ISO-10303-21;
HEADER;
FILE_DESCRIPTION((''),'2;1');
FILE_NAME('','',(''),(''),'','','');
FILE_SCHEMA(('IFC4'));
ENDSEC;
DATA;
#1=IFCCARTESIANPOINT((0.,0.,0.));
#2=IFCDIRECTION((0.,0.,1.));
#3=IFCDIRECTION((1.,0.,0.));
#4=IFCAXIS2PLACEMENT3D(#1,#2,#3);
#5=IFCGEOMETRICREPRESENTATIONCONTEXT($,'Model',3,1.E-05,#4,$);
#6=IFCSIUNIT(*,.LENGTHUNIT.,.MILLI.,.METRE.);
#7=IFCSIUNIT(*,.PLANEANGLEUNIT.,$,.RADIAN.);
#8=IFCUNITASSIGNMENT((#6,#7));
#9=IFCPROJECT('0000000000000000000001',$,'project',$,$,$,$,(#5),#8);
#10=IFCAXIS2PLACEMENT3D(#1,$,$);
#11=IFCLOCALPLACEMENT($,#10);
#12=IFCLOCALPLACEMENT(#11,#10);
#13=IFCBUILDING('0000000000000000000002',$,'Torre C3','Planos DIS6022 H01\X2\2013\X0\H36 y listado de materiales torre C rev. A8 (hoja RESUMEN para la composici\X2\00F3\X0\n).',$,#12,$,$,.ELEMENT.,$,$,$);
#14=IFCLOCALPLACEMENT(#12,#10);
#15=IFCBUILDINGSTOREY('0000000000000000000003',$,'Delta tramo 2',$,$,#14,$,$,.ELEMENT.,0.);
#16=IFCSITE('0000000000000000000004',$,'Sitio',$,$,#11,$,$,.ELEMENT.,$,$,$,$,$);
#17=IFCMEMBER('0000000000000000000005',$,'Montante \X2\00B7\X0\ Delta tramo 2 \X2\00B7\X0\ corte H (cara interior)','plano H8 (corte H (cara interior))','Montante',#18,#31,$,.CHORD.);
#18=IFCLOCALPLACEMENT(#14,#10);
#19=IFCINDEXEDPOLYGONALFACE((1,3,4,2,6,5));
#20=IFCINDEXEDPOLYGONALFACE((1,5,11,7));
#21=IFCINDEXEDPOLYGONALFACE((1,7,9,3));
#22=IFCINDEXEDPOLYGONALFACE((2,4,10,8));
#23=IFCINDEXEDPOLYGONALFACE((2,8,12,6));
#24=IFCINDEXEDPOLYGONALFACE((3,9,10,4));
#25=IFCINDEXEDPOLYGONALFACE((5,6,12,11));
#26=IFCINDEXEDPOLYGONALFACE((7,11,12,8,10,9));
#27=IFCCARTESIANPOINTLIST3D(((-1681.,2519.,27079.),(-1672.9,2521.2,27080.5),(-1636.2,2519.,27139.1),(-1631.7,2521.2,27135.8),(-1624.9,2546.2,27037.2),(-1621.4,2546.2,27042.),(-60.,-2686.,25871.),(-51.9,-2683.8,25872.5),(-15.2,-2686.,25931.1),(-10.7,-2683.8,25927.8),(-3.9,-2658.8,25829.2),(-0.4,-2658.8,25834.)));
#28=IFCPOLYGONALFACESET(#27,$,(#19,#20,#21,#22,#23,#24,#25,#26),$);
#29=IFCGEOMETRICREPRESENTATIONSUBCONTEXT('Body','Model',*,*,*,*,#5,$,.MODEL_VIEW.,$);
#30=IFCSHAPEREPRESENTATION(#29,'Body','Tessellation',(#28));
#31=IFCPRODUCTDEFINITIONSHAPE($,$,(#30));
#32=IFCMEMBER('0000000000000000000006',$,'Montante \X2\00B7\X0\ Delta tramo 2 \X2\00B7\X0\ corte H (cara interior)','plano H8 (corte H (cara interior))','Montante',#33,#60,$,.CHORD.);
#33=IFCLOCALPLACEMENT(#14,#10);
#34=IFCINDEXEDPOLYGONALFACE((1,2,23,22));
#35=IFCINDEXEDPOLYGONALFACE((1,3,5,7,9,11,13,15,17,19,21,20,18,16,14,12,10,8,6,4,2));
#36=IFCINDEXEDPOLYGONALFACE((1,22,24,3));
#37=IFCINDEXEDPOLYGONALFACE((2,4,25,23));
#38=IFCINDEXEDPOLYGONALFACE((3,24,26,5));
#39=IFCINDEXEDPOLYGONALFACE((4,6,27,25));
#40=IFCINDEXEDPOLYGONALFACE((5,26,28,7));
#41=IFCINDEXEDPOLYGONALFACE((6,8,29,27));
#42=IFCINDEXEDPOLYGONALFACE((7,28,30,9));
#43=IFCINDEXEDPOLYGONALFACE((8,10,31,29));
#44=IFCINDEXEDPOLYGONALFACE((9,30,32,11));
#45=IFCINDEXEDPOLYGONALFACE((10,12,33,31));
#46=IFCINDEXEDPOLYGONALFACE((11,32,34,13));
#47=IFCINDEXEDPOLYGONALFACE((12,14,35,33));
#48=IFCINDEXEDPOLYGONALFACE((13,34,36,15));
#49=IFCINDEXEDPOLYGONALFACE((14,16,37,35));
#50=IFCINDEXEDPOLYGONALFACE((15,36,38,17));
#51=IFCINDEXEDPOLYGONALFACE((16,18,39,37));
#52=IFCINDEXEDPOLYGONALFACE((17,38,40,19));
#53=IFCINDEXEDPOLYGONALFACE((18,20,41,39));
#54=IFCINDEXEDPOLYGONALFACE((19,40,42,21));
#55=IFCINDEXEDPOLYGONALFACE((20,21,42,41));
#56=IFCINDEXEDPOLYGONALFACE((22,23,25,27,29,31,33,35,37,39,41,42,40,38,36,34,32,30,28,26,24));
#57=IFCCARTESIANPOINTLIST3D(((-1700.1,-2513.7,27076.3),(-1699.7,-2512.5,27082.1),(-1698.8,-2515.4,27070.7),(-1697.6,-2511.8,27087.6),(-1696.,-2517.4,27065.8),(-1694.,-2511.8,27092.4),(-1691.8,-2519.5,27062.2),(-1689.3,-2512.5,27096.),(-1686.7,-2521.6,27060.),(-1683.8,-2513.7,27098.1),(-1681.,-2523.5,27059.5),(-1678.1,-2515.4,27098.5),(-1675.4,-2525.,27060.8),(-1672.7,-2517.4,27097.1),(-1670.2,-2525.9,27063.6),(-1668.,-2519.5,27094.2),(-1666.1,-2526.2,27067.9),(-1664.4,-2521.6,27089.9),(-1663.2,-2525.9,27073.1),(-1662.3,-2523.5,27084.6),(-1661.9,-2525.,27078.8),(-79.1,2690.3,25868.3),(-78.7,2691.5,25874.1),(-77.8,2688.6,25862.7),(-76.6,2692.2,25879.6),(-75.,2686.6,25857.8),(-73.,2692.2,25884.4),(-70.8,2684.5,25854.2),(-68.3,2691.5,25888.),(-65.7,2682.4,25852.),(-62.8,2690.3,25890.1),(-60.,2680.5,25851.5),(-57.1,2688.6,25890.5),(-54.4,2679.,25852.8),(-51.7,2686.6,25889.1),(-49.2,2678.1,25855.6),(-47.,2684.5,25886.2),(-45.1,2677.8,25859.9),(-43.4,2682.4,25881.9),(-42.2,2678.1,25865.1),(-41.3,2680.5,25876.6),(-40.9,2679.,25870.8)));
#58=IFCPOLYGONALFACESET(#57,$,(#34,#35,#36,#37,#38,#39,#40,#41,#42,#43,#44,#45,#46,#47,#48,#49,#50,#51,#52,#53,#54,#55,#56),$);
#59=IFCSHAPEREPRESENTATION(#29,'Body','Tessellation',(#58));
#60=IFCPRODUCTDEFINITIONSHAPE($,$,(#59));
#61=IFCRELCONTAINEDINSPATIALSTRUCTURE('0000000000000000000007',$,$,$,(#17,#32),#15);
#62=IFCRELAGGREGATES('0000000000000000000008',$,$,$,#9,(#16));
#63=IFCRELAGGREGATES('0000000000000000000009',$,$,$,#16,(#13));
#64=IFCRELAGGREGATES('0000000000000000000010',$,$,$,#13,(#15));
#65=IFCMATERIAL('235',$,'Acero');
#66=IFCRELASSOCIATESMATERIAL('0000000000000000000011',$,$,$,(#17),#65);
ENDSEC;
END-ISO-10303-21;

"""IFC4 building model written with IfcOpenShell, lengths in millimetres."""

from ifc_helpers import new_model, si_unit, frame, frame_2d, origin, origin_with_axes, place, context, subcontext, project, spatial, circle, l_section, extrude, material, element, save


model = new_model("IFC4")

# Units and contexts
model_context = context("Model", 3, precision=1e-05, world=origin_with_axes())
body_context = subcontext(model_context, "Body", "Model", "MODEL_VIEW")
ifc_project = project(units=[si_unit("LENGTHUNIT", "METRE", prefix="MILLI"), si_unit("PLANEANGLEUNIT", "RADIAN")], contexts=[model_context])

# Site, building, storey
site_placement = place(None, origin())
site = spatial("IfcSite", under=ifc_project, at=site_placement, Name="Sitio", CompositionType="ELEMENT")
building_placement = place(site_placement, origin())
building = spatial("IfcBuilding", under=site, at=building_placement, Name="Torre C3", Description="Planos DIS6022 H01–H36 y listado de materiales torre C rev. A8 (hoja RESUMEN para la composición).", CompositionType="ELEMENT")
storey_placement = place(building_placement, origin())
storey = spatial("IfcBuildingStorey", under=building, at=storey_placement, Name="Delta tramo 2", CompositionType="ELEMENT", Elevation=0.0)

# Members
ifc_material = material(Name="235", Category="Acero")
member_1_placement = place(storey_placement, frame((-1681.0, 2519.0, 27079.0), z_axis=(0.290304, -0.932159, -0.21634), x_axis=(0.747439, 0.362048, -0.557006)))
element("IfcMember", 1, at=member_1_placement, inside=storey, material=ifc_material, Name="Montante · Delta tramo 2 · corte H (cara interior)", Description="plano H8 (corte H (cara interior))", ObjectType="Montante", PredefinedType="CHORD", context=body_context, shape_type="SweptSolid", body=[
    extrude(l_section(Depth=75.0, Width=75.0, Thickness=6.0, at=frame_2d((37.5, 37.5))), None, (0.0, 0.0, 1.0), 5583.8),
])
member_2_placement = place(storey_placement, frame((-60.0, 2685.0, 25871.0), z_axis=(-0.290352, -0.932136, 0.216376), x_axis=(0.74742, -0.362109, -0.556992)))
element("IfcMember", 2, at=member_2_placement, inside=storey, Name="Montante · Delta tramo 2 · corte H (cara interior)", Description="plano H8 (corte H (cara interior))", ObjectType="Montante", PredefinedType="CHORD", context=body_context, shape_type="SweptSolid", body=[
    extrude(circle(Radius=20.0), None, (0.0, 0.0, 1.0), 5582.9),
])

save(model, "model.ifc")
